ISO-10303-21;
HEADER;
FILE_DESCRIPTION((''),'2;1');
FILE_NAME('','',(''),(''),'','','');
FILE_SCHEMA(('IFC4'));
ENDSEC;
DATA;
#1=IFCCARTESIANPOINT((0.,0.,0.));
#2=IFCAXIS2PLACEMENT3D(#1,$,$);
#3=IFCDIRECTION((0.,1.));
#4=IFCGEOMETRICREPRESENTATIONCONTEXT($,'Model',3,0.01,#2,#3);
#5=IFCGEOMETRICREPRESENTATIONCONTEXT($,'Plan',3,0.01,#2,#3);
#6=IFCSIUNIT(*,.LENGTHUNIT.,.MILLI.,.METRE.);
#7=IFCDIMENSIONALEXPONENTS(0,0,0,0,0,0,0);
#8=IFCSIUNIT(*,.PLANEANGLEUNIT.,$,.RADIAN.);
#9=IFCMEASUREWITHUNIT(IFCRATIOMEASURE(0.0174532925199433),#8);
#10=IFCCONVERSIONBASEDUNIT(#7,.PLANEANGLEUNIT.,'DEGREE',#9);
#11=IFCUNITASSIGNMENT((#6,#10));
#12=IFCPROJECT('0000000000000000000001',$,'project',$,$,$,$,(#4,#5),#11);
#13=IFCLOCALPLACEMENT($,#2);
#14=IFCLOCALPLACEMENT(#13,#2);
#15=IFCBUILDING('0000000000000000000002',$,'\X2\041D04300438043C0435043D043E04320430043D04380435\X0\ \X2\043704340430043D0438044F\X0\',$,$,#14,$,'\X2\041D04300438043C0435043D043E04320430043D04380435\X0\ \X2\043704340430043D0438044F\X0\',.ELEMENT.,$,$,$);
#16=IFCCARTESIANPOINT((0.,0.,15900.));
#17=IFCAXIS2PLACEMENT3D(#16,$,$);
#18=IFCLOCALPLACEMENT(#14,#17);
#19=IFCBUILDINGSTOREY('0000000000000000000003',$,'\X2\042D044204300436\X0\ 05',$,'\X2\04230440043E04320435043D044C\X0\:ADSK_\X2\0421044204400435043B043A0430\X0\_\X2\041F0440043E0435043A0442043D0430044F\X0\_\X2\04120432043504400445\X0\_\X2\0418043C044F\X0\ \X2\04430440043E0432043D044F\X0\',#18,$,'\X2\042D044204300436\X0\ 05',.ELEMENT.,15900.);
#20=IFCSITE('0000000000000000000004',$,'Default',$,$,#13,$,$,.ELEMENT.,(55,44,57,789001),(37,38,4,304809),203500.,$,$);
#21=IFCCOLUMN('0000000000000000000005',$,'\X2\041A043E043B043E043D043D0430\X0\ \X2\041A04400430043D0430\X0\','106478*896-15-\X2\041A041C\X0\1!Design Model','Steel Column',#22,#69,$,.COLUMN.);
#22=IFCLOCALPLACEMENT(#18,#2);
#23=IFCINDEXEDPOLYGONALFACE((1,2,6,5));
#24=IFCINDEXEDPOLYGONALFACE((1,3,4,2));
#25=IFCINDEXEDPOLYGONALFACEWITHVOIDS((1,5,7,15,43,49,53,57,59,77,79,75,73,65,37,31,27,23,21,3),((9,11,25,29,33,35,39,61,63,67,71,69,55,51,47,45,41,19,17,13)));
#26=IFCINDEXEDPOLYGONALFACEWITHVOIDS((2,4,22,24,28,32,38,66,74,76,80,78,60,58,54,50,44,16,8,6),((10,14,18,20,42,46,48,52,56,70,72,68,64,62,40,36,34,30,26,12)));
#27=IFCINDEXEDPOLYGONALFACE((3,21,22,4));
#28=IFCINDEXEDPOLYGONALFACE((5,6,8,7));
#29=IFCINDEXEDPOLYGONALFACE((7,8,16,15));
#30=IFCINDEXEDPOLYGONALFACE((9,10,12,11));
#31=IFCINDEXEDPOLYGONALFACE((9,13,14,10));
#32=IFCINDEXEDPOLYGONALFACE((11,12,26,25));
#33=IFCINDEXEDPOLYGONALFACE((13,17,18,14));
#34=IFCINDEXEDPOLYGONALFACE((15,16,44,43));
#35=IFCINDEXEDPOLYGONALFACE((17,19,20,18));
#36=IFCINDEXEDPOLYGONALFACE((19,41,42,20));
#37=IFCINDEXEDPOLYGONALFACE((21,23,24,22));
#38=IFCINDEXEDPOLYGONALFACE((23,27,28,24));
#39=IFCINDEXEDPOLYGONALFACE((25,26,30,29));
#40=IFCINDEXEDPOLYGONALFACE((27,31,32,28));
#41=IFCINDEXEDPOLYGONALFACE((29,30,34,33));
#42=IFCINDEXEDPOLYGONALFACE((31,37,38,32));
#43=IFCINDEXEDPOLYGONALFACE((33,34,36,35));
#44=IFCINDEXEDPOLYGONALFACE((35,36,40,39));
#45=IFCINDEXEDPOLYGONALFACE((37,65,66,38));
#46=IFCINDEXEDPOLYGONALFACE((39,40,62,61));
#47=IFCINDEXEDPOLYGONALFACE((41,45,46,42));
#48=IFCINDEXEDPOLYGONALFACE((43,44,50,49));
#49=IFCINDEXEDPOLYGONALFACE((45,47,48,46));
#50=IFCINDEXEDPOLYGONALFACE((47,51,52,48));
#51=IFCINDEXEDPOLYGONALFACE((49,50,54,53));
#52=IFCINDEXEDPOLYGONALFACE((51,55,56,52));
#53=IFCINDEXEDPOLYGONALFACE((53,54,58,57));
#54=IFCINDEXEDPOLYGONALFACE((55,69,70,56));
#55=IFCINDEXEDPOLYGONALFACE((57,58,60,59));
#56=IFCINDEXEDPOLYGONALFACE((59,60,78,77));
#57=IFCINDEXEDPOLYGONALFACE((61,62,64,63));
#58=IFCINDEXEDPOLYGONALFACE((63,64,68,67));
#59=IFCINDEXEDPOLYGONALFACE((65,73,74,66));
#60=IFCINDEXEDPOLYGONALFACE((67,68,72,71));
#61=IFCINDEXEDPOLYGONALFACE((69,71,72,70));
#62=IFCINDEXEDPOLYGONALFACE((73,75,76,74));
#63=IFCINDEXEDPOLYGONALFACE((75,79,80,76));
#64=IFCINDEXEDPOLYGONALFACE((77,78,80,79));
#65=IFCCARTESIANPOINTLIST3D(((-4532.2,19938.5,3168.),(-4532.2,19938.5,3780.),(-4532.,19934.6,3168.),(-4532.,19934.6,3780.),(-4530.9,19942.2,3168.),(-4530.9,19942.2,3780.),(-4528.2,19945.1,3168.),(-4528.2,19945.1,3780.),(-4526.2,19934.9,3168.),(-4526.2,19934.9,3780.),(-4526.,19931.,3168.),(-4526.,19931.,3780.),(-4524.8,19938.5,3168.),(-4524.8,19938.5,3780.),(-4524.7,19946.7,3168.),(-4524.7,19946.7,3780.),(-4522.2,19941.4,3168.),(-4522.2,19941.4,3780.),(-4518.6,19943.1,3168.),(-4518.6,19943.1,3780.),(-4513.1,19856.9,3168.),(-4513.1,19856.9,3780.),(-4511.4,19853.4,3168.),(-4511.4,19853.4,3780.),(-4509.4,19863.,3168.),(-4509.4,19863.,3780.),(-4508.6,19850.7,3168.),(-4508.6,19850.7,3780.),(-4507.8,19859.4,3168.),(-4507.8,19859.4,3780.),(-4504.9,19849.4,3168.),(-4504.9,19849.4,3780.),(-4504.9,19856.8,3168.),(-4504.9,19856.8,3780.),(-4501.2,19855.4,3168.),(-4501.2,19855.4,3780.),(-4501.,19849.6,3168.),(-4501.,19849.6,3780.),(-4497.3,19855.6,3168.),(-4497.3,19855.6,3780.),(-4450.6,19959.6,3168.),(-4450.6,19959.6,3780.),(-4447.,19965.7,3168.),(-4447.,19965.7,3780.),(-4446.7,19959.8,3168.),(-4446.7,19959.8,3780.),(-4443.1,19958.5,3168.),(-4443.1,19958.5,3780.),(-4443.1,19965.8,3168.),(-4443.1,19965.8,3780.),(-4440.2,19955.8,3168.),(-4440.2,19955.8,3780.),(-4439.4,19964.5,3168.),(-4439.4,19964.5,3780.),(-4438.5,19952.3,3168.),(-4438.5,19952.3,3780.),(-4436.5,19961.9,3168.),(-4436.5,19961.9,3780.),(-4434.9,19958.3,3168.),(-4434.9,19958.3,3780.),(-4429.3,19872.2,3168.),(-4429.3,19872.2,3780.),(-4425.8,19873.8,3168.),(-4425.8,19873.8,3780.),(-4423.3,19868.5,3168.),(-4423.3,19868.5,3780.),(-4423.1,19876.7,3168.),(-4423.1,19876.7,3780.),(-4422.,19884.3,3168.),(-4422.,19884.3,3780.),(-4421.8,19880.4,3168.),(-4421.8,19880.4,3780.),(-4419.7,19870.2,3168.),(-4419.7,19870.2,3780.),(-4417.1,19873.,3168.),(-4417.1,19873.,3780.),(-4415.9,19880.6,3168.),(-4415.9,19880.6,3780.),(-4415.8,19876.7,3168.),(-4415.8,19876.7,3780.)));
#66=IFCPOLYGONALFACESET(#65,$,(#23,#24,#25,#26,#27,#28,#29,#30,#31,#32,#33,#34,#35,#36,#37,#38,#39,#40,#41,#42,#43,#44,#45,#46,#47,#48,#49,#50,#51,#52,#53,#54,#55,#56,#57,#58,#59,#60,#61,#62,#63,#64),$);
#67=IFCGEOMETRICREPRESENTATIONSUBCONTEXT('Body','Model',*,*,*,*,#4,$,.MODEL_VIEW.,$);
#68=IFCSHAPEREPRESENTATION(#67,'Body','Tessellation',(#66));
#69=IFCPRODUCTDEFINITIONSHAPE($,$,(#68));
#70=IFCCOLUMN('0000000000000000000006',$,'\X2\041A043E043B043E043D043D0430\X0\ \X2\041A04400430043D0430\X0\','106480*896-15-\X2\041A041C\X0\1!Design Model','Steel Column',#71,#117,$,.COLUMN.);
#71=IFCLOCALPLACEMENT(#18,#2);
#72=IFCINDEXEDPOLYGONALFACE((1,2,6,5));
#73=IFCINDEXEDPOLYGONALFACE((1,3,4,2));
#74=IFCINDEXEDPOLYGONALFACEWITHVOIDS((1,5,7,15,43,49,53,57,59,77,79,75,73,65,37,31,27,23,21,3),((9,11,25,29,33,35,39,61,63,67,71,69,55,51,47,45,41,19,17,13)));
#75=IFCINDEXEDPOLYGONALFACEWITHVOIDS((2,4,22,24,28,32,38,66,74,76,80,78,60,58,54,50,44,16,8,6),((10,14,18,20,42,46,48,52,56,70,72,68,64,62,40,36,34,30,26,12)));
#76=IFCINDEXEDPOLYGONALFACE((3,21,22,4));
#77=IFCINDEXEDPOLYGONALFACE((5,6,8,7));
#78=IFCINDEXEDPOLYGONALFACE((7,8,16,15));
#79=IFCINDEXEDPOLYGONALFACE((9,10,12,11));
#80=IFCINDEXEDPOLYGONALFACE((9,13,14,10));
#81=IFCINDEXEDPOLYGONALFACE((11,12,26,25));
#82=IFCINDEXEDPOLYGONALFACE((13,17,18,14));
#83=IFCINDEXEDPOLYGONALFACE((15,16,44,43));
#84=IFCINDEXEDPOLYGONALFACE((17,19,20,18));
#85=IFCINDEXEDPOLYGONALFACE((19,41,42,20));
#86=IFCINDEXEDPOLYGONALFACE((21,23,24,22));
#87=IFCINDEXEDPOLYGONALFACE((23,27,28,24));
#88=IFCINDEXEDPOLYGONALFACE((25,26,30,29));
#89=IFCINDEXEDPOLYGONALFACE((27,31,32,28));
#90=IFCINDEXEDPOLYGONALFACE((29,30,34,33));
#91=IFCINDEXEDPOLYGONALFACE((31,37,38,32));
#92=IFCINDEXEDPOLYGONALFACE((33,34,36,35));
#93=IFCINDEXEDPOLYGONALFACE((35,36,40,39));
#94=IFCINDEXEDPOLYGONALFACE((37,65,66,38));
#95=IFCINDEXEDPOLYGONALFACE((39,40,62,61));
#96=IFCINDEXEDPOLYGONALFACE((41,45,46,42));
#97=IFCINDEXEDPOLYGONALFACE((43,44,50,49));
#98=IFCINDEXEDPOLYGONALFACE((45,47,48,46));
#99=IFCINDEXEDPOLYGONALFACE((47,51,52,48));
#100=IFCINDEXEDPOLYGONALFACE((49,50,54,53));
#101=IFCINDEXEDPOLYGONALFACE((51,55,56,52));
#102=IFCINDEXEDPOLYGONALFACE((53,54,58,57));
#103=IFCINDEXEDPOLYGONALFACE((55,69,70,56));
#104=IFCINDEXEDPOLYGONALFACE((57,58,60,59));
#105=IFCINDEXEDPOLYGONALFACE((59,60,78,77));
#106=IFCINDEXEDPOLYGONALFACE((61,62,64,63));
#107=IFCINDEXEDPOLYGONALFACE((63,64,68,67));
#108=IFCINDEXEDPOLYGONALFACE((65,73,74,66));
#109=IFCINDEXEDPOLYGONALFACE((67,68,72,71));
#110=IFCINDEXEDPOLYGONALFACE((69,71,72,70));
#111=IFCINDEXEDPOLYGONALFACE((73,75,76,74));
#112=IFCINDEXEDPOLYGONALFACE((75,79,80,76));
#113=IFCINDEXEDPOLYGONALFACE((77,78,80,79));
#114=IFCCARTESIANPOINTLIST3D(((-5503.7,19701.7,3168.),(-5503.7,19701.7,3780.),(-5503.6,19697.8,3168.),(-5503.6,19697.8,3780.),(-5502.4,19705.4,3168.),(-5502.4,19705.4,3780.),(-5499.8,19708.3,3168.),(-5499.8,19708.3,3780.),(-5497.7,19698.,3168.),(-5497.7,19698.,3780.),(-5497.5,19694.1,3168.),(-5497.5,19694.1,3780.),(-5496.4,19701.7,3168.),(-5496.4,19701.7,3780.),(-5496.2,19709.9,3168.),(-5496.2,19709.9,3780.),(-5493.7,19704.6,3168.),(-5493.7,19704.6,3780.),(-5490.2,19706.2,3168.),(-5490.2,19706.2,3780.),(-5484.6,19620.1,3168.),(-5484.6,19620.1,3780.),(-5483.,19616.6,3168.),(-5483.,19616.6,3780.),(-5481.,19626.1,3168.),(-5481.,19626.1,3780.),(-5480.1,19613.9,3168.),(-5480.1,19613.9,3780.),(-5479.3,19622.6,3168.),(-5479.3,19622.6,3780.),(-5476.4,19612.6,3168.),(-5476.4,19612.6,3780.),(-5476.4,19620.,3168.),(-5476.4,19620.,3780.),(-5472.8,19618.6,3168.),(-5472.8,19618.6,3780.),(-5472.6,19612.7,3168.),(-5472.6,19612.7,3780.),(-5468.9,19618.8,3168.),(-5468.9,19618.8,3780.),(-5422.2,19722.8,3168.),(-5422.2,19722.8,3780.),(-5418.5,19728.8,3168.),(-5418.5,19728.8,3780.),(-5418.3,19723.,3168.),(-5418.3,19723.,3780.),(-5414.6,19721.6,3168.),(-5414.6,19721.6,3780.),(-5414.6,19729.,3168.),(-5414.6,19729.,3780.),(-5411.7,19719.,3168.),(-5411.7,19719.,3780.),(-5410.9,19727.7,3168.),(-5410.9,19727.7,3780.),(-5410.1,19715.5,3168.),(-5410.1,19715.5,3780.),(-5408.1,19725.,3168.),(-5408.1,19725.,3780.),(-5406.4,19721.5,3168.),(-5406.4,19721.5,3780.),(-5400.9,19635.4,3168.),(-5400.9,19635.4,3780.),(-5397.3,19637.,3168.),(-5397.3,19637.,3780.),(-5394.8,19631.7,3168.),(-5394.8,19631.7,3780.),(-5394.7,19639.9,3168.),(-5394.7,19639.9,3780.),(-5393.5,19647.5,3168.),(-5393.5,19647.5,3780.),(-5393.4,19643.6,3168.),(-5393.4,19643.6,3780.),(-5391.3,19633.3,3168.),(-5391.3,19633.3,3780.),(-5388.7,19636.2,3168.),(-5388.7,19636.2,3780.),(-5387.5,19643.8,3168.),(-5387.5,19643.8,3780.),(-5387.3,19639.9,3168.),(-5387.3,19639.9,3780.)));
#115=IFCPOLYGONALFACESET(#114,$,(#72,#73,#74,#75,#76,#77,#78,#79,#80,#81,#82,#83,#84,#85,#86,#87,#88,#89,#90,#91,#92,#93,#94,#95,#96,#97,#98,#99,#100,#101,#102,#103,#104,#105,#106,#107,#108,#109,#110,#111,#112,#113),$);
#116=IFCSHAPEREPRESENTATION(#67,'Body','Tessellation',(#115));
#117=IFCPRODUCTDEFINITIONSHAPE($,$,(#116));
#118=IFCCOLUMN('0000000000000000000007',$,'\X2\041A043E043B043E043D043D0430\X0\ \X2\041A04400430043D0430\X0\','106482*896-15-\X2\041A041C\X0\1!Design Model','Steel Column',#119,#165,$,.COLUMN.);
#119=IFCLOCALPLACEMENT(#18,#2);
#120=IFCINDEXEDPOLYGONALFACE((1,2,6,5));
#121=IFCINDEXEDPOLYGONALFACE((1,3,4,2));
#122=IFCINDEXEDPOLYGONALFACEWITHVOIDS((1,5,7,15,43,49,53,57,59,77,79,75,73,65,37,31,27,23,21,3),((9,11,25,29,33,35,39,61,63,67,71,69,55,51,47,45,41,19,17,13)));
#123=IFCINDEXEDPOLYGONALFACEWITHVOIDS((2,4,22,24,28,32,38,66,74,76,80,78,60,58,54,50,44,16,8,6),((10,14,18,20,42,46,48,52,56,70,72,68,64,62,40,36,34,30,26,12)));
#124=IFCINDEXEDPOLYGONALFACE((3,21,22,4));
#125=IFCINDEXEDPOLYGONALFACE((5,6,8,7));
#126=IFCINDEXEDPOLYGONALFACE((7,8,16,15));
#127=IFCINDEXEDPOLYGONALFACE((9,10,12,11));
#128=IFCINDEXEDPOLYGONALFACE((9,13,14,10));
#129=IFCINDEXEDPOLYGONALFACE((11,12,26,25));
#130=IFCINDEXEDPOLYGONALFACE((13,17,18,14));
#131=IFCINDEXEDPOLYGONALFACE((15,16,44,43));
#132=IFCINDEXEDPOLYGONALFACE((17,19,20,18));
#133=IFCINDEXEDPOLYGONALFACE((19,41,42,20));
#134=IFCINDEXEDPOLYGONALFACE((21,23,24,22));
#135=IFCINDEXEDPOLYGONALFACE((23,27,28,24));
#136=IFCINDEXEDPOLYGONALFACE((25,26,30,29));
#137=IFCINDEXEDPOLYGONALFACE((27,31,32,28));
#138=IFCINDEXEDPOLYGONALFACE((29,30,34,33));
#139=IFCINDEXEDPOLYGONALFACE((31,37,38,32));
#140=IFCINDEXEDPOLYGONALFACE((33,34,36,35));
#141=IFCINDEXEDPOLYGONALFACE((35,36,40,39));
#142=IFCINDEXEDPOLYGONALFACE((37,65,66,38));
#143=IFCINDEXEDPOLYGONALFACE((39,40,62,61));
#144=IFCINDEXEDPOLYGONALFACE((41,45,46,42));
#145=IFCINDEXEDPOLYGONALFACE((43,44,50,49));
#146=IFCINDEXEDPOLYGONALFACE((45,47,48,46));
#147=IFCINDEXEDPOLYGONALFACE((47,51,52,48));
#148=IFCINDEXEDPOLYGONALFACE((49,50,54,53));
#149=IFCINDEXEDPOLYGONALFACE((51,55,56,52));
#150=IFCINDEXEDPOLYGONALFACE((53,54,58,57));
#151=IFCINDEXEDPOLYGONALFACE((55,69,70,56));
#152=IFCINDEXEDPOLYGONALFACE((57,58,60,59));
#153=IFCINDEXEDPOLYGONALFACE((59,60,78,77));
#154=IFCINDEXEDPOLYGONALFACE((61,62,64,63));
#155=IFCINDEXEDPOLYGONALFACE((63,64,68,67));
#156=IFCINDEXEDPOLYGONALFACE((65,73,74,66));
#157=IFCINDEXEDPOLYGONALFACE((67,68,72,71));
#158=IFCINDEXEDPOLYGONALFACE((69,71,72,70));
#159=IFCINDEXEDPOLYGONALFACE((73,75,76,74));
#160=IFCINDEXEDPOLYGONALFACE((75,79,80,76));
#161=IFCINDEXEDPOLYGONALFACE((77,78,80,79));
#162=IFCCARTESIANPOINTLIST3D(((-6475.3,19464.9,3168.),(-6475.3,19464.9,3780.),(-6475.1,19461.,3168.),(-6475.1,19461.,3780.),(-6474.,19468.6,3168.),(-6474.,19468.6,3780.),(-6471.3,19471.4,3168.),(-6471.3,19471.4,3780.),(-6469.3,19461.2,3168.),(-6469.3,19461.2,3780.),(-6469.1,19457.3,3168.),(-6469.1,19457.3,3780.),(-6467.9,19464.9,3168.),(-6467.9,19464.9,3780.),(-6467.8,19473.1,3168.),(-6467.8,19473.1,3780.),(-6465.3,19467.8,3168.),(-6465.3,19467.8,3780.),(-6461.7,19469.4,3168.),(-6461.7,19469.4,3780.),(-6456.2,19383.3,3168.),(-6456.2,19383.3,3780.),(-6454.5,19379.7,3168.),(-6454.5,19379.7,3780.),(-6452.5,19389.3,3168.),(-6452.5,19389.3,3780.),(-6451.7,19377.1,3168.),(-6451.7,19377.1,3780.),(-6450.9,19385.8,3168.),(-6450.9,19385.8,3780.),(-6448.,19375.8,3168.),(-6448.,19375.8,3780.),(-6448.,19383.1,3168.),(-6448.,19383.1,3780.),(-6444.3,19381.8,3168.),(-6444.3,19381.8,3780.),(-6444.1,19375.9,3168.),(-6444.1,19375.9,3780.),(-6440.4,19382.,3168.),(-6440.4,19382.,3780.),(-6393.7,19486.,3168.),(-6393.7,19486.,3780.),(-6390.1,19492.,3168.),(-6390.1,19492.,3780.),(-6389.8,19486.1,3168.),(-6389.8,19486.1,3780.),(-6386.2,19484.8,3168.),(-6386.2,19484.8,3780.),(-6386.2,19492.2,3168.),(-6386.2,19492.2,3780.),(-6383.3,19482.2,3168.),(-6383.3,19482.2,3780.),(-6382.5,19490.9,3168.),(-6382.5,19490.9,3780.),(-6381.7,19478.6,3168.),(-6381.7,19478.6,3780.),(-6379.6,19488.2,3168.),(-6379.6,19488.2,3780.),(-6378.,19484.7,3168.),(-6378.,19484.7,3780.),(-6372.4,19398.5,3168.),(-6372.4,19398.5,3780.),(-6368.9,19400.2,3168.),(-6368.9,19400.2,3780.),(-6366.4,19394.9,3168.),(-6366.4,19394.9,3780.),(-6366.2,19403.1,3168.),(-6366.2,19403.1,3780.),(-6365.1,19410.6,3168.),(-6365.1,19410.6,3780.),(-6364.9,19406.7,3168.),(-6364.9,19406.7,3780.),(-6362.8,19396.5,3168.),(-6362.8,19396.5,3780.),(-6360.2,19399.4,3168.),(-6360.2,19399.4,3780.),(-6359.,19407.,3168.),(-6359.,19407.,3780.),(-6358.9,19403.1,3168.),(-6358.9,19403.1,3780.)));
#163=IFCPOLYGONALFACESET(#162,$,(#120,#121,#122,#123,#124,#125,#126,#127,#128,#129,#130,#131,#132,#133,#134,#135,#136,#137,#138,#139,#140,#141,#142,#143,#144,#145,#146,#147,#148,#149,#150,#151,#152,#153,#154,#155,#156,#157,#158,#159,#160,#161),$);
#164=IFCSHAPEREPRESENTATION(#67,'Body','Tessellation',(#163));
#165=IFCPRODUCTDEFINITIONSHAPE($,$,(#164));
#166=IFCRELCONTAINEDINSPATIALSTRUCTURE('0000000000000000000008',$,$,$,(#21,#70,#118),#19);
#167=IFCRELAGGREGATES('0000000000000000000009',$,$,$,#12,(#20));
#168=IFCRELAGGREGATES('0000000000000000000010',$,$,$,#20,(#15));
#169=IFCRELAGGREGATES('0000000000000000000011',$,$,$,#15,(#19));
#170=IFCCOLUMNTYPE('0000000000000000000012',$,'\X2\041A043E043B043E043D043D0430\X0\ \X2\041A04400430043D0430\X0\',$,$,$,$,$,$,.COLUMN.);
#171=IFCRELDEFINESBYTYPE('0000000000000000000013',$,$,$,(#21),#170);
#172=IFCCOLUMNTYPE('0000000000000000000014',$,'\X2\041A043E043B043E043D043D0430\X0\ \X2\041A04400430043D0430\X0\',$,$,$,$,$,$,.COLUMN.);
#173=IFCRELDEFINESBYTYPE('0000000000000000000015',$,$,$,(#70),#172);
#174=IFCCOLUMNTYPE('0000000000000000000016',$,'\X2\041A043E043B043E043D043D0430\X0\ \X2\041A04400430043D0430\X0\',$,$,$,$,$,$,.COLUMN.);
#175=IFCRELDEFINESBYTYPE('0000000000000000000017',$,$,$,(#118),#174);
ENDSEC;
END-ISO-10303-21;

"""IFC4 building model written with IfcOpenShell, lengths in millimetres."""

from ifc_helpers import new_model, entity, si_unit, converted_unit, direction, frame, origin, place, context, subcontext, project, spatial, indexed_curve, outline, extrude, type_object, element, save


model = new_model("IFC4")

# Units and contexts
model_context = context("Model", 3, precision=0.01, world=origin(), true_north=direction((0.0, 1.0)))
plan_context = context("Plan", 3, precision=0.01, world=origin(), true_north=direction((0.0, 1.0)))
body_context = subcontext(model_context, "Body", "Model", "MODEL_VIEW")
ifc_project = project(units=[si_unit("LENGTHUNIT", "METRE", prefix="MILLI"), converted_unit("PLANEANGLEUNIT", "DEGREE", entity("IfcRatioMeasure", 0.0174532925199433), si_unit("PLANEANGLEUNIT", "RADIAN"), dimensions=[0, 0, 0, 0, 0, 0, 0])], contexts=[model_context, plan_context])

# Site, building, storey
site_placement = place(None, origin())
site = spatial("IfcSite", under=ifc_project, at=site_placement, Name="Default", CompositionType="ELEMENT", RefLatitude=(55, 44, 57, 789001), RefLongitude=(37, 38, 4, 304809), RefElevation=203500.0)
building_placement = place(site_placement, origin())
building = spatial("IfcBuilding", under=site, at=building_placement, Name="Наименование здания", LongName="Наименование здания", CompositionType="ELEMENT")
storey_placement = place(building_placement, frame((0.0, 0.0, 15900.0)))
storey = spatial("IfcBuildingStorey", under=building, at=storey_placement, Name="Этаж 05", ObjectType="Уровень:ADSK_Стрелка_Проектная_Вверх_Имя уровня", LongName="Этаж 05", CompositionType="ELEMENT", Elevation=15900.0)

# Columns
column_type_1 = type_object("IfcColumnType", Name="Колонна Крана", PredefinedType="COLUMN")
column_1_placement = place(storey_placement, origin())
element("IfcColumn", 1, at=column_1_placement, inside=storey, type_object=column_type_1, Name="Колонна Крана", Description="106478*896-15-КМ1!Design Model", ObjectType="Steel Column", PredefinedType="COLUMN", context=body_context, shape_type="SweptSolid", body=[
    extrude(outline(indexed_curve([(29.5, -56.8), (33.4, -56.8), (37.0, -55.3), (39.7, -52.6), (41.2, -49.0), (56.8, 29.5), (56.8, 33.4), (55.3, 37.0), (52.6, 39.7), (49.0, 41.2), (-29.5, 56.8), (-33.4, 56.8), (-37.0, 55.3), (-39.7, 52.6), (-41.2, 49.0), (-56.8, -29.5), (-56.8, -33.4), (-55.3, -37.0), (-52.6, -39.7), (-49.0, -41.2), (29.5, -56.8)], self_intersect=False), holes=[indexed_curve([(-43.1, -37.3), (-46.7, -35.8), (-49.5, -33.1), (-51.0, -29.5), (-51.0, -25.5), (-37.3, 43.1), (-35.8, 46.7), (-33.1, 49.5), (-29.5, 51.0), (-25.5, 51.0), (43.1, 37.3), (46.7, 35.8), (49.5, 33.1), (51.0, 29.5), (51.0, 25.5), (37.3, -43.1), (35.8, -46.7), (33.1, -49.5), (29.5, -51.0), (25.5, -51.0), (-43.1, -37.3)], self_intersect=False)]), frame((-4474.0, 19907.6, 3168.0), z_axis=(0.0, 0.0, 1.0), x_axis=(0.906681, 0.421816, 0.0)), (0.0, 0.0, 1.0), 612.0),
])
column_type_2 = type_object("IfcColumnType", Name="Колонна Крана", PredefinedType="COLUMN")
column_2_placement = place(storey_placement, origin())
element("IfcColumn", 2, at=column_2_placement, inside=storey, type_object=column_type_2, Name="Колонна Крана", Description="106480*896-15-КМ1!Design Model", ObjectType="Steel Column", PredefinedType="COLUMN", context=body_context, shape_type="SweptSolid", body=[
    extrude(outline(indexed_curve([(29.5, -56.8), (33.4, -56.8), (37.0, -55.3), (39.7, -52.6), (41.2, -49.0), (56.8, 29.5), (56.8, 33.4), (55.3, 37.0), (52.6, 39.7), (49.0, 41.2), (-29.5, 56.8), (-33.4, 56.8), (-37.0, 55.3), (-39.7, 52.6), (-41.2, 49.0), (-56.8, -29.5), (-56.8, -33.4), (-55.3, -37.0), (-52.6, -39.7), (-49.0, -41.2), (29.5, -56.8)], self_intersect=False), holes=[indexed_curve([(-43.1, -37.3), (-46.7, -35.8), (-49.5, -33.1), (-51.0, -29.5), (-51.0, -25.5), (-37.3, 43.1), (-35.8, 46.7), (-33.1, 49.5), (-29.5, 51.0), (-25.5, 51.0), (43.1, 37.3), (46.7, 35.8), (49.5, 33.1), (51.0, 29.5), (51.0, 25.5), (37.3, -43.1), (35.8, -46.7), (33.1, -49.5), (29.5, -51.0), (25.5, -51.0), (-43.1, -37.3)], self_intersect=False)]), frame((-5445.5, 19670.8, 3168.0), z_axis=(0.0, 0.0, 1.0), x_axis=(0.906681, 0.421816, 0.0)), (0.0, 0.0, 1.0), 612.0),
])
column_type_3 = type_object("IfcColumnType", Name="Колонна Крана", PredefinedType="COLUMN")
column_3_placement = place(storey_placement, origin())
element("IfcColumn", 3, at=column_3_placement, inside=storey, type_object=column_type_3, Name="Колонна Крана", Description="106482*896-15-КМ1!Design Model", ObjectType="Steel Column", PredefinedType="COLUMN", context=body_context, shape_type="SweptSolid", body=[
    extrude(outline(indexed_curve([(29.5, -56.8), (33.4, -56.8), (37.0, -55.3), (39.7, -52.6), (41.2, -49.0), (56.8, 29.5), (56.8, 33.4), (55.3, 37.0), (52.6, 39.7), (49.0, 41.2), (-29.5, 56.8), (-33.4, 56.8), (-37.0, 55.3), (-39.7, 52.6), (-41.2, 49.0), (-56.8, -29.5), (-56.8, -33.4), (-55.3, -37.0), (-52.6, -39.7), (-49.0, -41.2), (29.5, -56.8)], self_intersect=False), holes=[indexed_curve([(-43.1, -37.3), (-46.7, -35.8), (-49.5, -33.1), (-51.0, -29.5), (-51.0, -25.5), (-37.3, 43.1), (-35.8, 46.7), (-33.1, 49.5), (-29.5, 51.0), (-25.5, 51.0), (43.1, 37.3), (46.7, 35.8), (49.5, 33.1), (51.0, 29.5), (51.0, 25.5), (37.3, -43.1), (35.8, -46.7), (33.1, -49.5), (29.5, -51.0), (25.5, -51.0), (-43.1, -37.3)], self_intersect=False)]), frame((-6417.1, 19434.0, 3168.0), z_axis=(0.0, 0.0, 1.0), x_axis=(0.906681, 0.421816, 0.0)), (0.0, 0.0, 1.0), 612.0),
])

save(model, "model.ifc")
